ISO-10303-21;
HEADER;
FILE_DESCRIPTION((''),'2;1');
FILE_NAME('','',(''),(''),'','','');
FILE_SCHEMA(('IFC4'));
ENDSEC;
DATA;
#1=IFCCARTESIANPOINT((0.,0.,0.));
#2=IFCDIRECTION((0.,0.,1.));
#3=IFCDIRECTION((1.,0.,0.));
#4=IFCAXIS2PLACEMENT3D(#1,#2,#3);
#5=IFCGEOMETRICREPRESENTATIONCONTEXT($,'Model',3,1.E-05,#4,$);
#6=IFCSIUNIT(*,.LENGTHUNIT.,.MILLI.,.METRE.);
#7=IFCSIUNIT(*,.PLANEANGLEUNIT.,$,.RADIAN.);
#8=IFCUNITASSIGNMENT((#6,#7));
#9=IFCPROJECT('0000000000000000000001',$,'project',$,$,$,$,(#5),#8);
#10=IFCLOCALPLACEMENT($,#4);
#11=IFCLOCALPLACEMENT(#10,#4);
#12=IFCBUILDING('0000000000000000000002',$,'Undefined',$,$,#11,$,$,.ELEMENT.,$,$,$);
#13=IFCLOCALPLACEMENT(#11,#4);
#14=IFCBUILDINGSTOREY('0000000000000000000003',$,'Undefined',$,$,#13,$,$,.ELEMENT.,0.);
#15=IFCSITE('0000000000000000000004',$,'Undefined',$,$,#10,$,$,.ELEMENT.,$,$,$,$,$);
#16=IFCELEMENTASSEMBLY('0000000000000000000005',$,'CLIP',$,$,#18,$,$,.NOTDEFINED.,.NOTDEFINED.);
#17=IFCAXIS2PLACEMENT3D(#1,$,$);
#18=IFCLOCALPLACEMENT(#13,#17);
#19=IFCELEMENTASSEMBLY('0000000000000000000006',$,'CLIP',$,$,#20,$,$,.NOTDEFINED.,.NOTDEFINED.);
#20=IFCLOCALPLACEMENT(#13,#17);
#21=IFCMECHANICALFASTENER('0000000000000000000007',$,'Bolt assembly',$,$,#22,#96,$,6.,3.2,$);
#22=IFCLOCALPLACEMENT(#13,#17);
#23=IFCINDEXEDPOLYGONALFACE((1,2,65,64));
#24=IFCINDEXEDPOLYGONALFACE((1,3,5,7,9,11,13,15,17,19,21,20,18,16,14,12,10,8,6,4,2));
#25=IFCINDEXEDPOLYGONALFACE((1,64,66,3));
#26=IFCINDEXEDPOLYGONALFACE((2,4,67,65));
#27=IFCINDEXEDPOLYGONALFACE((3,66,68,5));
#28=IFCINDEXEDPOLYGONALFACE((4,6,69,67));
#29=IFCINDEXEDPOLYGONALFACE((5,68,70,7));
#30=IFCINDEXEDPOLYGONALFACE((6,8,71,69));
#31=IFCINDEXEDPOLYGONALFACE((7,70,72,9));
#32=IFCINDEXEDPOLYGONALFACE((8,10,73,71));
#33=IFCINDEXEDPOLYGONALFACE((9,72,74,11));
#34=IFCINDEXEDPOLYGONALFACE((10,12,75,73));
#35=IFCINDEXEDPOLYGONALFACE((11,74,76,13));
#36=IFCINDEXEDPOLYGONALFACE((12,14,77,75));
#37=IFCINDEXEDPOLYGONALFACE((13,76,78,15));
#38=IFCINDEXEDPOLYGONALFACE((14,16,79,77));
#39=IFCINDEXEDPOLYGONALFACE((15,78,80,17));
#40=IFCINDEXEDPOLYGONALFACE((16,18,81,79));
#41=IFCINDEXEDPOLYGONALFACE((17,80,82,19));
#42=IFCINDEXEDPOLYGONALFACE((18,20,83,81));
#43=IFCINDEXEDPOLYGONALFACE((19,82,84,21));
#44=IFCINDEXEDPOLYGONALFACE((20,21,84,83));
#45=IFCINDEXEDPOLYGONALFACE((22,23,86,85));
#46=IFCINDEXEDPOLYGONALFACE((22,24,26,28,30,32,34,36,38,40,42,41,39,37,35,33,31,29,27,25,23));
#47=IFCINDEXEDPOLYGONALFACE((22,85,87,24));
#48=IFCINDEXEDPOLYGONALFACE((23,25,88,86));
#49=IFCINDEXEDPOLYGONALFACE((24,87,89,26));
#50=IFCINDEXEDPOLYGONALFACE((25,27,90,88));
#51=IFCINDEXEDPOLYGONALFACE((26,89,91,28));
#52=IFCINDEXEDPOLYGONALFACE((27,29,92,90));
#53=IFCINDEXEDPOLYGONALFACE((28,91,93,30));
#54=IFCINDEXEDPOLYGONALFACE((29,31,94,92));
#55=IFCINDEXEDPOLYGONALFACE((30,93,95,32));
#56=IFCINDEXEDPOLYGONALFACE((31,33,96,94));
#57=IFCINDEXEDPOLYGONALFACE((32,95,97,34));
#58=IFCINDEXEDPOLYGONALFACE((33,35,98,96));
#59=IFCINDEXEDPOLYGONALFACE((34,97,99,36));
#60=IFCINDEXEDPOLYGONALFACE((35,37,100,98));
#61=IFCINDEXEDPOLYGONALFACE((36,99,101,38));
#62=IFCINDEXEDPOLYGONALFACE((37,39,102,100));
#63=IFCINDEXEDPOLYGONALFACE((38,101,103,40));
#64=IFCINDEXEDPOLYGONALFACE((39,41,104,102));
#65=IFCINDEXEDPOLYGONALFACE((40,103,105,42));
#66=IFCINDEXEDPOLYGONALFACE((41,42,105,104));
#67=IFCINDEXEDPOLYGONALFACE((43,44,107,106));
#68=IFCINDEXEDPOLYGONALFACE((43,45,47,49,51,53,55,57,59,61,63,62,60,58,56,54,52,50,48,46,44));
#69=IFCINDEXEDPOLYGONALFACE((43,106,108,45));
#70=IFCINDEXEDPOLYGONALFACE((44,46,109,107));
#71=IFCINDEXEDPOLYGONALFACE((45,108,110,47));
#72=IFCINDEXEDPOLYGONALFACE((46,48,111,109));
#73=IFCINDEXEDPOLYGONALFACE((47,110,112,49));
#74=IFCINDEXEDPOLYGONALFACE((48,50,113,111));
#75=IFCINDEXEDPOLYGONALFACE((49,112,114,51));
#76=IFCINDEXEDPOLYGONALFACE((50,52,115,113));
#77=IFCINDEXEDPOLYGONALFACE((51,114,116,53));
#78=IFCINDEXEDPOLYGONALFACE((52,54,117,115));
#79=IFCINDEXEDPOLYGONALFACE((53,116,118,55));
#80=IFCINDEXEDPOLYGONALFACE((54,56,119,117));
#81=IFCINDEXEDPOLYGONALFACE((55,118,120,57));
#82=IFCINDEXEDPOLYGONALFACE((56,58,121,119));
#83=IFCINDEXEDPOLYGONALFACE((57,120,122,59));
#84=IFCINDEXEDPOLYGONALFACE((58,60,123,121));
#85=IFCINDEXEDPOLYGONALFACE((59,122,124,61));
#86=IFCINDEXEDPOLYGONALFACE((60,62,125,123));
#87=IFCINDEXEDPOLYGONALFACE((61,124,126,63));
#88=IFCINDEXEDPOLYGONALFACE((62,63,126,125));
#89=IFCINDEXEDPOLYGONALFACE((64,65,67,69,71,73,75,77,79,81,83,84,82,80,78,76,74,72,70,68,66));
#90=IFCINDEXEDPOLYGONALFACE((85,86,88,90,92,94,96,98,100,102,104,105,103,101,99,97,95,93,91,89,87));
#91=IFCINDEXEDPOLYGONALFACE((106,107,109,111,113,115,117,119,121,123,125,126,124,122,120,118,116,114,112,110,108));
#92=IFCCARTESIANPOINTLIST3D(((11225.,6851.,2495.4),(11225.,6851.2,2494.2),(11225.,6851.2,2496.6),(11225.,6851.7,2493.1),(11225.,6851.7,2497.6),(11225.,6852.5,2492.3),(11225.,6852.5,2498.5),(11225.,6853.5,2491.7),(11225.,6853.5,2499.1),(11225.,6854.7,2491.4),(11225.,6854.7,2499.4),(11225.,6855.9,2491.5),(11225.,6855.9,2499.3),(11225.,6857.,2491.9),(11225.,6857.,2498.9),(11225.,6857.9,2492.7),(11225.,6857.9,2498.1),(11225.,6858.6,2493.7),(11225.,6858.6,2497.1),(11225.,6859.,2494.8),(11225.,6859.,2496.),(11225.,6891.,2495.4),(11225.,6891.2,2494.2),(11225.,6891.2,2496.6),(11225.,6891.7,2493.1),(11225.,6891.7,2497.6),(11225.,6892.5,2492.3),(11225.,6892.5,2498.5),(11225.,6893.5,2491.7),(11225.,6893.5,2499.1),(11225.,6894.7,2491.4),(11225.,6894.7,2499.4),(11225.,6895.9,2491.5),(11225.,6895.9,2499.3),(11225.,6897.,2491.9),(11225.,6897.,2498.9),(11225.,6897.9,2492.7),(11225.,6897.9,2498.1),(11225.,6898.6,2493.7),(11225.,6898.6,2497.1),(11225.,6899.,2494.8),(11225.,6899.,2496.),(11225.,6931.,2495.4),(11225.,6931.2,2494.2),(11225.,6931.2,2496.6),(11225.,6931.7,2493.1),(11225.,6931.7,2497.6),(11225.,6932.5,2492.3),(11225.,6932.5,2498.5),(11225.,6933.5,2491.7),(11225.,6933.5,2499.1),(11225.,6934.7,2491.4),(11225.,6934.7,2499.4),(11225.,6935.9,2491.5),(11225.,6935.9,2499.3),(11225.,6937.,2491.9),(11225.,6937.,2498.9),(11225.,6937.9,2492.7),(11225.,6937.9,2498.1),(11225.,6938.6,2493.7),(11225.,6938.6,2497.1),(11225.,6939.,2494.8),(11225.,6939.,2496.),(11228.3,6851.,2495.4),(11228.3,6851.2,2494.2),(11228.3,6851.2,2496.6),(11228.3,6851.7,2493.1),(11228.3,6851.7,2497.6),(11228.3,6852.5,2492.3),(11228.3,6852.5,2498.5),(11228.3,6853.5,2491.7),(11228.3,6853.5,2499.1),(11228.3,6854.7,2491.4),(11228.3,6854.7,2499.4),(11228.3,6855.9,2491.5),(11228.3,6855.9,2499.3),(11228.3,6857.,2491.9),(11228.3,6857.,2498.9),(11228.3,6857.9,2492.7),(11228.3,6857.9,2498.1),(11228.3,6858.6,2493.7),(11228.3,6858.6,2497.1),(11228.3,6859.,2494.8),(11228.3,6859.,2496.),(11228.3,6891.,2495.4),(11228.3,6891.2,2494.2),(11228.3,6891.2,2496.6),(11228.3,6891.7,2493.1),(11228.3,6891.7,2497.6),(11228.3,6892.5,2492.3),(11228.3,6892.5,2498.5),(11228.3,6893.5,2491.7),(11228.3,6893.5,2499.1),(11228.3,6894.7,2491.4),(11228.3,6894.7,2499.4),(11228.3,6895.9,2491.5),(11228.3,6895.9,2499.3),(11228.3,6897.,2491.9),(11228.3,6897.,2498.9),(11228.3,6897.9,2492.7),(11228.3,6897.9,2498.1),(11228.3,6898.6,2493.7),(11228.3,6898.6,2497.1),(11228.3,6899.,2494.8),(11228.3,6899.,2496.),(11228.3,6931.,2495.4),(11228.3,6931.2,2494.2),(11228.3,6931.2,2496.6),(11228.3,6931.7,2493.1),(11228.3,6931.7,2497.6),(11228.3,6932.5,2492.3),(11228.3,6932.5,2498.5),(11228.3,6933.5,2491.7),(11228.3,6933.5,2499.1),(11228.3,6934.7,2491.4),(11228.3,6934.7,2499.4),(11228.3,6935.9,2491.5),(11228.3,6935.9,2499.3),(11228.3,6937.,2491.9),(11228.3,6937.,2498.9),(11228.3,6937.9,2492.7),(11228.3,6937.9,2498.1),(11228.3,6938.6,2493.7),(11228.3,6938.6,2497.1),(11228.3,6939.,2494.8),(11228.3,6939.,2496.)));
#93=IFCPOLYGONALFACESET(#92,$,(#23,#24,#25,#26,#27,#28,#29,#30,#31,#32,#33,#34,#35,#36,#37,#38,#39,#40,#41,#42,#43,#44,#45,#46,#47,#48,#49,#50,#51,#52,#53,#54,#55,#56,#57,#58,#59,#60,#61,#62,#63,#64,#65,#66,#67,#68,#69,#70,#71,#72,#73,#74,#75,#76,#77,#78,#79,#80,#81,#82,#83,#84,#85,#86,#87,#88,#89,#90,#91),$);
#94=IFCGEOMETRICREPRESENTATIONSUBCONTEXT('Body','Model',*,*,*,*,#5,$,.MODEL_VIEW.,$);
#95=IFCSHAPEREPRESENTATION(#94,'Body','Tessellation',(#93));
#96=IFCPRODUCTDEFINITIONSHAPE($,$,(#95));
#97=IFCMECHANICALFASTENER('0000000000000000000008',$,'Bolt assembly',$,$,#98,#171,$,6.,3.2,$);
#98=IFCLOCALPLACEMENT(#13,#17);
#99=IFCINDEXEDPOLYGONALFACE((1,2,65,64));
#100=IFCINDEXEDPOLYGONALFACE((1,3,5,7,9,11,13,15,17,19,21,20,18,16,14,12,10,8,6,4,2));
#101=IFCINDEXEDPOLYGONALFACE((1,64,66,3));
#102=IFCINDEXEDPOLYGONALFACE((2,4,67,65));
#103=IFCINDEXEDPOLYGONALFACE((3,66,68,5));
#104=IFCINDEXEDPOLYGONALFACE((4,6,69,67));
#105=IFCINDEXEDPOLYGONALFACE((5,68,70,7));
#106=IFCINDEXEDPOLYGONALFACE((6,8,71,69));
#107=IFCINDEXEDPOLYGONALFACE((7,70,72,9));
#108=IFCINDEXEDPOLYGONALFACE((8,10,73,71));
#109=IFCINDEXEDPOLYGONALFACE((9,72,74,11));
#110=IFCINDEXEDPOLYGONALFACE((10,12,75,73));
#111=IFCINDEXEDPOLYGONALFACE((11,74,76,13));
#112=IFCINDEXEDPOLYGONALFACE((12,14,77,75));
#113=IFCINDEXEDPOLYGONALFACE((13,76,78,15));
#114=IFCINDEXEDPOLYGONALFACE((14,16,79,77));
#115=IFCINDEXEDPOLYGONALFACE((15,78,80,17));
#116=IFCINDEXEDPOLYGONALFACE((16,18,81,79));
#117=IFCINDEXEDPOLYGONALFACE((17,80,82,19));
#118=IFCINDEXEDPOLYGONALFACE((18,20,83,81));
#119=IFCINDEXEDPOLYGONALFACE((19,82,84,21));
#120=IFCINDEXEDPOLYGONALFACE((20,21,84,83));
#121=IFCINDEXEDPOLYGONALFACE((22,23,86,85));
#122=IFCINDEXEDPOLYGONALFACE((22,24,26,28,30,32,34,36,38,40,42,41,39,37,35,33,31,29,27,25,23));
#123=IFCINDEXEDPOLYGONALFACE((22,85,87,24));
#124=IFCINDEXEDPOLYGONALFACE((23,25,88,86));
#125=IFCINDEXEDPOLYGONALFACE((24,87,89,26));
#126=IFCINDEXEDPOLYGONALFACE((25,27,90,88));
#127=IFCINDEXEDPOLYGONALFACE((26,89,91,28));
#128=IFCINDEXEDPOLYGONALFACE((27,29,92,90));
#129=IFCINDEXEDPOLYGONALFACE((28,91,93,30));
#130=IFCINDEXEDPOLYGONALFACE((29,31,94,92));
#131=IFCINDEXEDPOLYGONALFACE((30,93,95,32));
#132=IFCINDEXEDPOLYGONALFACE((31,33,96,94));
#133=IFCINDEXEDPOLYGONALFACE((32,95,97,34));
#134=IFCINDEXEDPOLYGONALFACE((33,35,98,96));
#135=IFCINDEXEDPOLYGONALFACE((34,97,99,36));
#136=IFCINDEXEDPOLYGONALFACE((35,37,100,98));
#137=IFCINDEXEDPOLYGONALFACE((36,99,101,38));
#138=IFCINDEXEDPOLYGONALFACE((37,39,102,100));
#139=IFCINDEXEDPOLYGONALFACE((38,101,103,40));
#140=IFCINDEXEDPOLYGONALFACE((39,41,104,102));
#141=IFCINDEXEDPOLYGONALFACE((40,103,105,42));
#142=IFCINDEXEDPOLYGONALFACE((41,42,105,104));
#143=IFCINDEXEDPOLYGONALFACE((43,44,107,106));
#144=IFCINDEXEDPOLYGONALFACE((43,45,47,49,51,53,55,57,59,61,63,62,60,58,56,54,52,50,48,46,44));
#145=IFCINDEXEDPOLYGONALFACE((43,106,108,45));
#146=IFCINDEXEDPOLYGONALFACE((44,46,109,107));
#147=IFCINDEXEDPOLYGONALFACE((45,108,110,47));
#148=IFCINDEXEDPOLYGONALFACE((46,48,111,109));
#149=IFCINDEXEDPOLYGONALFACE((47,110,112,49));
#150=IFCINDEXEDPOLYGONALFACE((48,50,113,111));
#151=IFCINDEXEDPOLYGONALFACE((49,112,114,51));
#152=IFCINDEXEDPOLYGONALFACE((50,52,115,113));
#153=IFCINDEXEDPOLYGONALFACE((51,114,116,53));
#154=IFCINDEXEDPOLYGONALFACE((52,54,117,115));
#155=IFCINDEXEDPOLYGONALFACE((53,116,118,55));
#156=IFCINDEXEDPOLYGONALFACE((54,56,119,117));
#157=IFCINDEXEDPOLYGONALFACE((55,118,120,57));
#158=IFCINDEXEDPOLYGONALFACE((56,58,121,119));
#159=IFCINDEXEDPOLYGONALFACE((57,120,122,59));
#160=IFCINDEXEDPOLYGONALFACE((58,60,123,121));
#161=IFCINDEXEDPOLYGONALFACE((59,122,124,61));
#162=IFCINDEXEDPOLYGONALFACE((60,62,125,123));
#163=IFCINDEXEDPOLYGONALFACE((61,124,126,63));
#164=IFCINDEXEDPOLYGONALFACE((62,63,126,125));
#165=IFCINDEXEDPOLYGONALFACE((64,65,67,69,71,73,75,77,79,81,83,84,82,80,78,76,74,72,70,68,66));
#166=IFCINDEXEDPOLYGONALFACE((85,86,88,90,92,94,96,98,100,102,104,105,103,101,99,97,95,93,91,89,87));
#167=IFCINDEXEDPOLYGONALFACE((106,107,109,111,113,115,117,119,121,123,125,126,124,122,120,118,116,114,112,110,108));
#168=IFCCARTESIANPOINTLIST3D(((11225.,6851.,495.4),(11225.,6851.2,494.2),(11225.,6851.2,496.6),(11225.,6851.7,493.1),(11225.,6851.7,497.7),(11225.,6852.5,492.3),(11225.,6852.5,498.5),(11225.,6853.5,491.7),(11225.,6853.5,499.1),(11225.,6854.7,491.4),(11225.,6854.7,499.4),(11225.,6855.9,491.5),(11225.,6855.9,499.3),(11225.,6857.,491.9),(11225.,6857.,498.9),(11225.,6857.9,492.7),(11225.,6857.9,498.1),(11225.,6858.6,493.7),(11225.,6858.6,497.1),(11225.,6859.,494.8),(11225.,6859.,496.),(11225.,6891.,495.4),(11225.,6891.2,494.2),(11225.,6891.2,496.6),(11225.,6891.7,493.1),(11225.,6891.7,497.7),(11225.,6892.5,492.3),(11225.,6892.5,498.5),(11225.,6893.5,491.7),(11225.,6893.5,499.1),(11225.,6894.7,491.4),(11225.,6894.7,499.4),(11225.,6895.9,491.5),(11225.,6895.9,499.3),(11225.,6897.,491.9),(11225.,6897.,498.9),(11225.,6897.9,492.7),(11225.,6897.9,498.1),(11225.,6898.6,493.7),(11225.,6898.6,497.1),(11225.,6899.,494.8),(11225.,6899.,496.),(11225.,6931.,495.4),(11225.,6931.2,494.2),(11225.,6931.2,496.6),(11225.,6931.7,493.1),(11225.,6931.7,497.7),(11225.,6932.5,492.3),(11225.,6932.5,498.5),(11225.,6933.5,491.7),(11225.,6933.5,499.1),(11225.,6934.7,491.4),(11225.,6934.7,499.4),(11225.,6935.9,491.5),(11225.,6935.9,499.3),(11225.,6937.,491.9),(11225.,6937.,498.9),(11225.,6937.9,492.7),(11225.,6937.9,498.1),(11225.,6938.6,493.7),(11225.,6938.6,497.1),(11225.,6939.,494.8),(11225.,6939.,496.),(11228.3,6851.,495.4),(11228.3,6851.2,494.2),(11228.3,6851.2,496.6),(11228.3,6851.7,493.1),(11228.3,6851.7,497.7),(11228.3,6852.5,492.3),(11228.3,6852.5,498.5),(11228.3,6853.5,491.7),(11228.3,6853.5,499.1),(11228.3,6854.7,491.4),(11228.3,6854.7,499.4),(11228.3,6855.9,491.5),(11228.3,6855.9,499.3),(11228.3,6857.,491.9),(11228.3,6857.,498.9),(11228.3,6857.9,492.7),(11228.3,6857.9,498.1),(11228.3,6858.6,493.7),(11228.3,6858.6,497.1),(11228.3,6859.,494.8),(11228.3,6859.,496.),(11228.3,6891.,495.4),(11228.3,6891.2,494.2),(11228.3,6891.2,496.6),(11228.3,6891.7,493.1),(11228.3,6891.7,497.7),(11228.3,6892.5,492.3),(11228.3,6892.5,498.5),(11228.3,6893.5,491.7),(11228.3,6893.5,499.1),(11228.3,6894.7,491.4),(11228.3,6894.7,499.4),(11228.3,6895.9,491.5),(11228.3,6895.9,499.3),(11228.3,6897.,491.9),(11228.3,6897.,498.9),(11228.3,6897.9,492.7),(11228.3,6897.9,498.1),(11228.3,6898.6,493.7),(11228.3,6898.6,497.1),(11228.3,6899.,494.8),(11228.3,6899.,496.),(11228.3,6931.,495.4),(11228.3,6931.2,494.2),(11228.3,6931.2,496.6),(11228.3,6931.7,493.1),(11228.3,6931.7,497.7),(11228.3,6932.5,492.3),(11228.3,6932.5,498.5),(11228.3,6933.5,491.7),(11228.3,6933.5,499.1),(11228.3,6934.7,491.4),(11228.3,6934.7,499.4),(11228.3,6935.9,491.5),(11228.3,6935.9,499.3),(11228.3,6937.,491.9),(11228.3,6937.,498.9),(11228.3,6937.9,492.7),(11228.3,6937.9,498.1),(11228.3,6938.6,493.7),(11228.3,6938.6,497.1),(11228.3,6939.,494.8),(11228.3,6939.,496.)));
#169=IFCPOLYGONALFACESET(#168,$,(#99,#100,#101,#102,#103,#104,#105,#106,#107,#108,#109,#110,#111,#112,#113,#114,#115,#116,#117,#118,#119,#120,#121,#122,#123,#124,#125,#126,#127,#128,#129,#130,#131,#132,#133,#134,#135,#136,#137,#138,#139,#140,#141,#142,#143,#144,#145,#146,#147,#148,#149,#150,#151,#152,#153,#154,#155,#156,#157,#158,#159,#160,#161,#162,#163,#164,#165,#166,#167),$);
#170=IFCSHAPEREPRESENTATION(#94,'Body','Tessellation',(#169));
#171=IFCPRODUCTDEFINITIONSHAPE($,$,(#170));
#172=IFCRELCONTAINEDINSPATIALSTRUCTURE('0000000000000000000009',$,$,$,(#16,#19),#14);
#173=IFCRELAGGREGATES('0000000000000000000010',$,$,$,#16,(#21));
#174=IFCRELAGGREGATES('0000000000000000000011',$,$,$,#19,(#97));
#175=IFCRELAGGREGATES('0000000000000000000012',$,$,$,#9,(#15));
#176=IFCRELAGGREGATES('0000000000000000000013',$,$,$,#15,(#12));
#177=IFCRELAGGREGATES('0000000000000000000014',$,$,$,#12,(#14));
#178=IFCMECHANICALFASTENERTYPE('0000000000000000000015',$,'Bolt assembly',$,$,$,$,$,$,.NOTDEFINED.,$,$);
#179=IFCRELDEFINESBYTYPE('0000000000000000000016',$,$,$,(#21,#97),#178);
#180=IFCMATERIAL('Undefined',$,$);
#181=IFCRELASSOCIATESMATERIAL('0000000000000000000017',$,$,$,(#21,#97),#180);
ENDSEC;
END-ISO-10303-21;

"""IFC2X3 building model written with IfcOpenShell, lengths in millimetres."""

from ifc_helpers import new_model, si_unit, frame, origin_with_axes, origin_2d_with_axis, place, context, subcontext, project, spatial, circle, extrude, source, transform, mapped, material, type_object, element, aggregate, save


model = new_model("IFC2X3")

# Units and contexts
model_context = context("Model", 3, precision=1e-05, world=origin_with_axes())
body_context = subcontext(model_context, "Body", "Model", "MODEL_VIEW")
ifc_project = project(units=[si_unit("LENGTHUNIT", "METRE", prefix="MILLI"), si_unit("PLANEANGLEUNIT", "RADIAN")], contexts=[model_context])

# Site, building, storey
site_placement = place(None, origin_with_axes())
site = spatial("IfcSite", under=ifc_project, at=site_placement, Name="Undefined", CompositionType="ELEMENT")
building_placement = place(site_placement, origin_with_axes())
building = spatial("IfcBuilding", under=site, at=building_placement, Name="Undefined", CompositionType="ELEMENT")
storey_placement = place(building_placement, origin_with_axes())
storey = spatial("IfcBuildingStorey", under=building, at=storey_placement, Name="Undefined", CompositionType="ELEMENT", Elevation=0.0)

# Element assemblies
assembly_1_placement = place(storey_placement, origin_with_axes())
assembly_1 = element("IfcElementAssembly", 1, at=assembly_1_placement, inside=storey, Name="CLIP", AssemblyPlace="NOTDEFINED", PredefinedType="NOTDEFINED")
assembly_2_placement = place(storey_placement, origin_with_axes())
assembly_2 = element("IfcElementAssembly", 2, at=assembly_2_placement, inside=storey, Name="CLIP", AssemblyPlace="NOTDEFINED", PredefinedType="NOTDEFINED")

# Mechanical fasteners
ifc_material_1 = material(Name="Undefined")
mechanical_fastener_type = type_object("IfcMechanicalFastenerType", Name="Bolt assembly")
shared_shape_1 = source(origin_with_axes(), body_context, "Body", "SweptSolid", [
    extrude(circle(Radius=4.0, at=origin_2d_with_axis()), frame((0.0, 0.0, 0.0), z_axis=(0.0, 1.0, 0.0), x_axis=(1.0, 0.0, 0.0)), (0.0, 0.0, 1.0), 3.3),
])
mechanical_fastener_1_placement = place(assembly_1_placement, frame((11225.0, 6935.0, 2495.4), z_axis=(0.0, 0.0, 1.0), x_axis=(0.0, -1.0, 0.0)))
mechanical_fastener_1 = element("IfcMechanicalFastener", 3, at=mechanical_fastener_1_placement, type_object=mechanical_fastener_type, material=ifc_material_1, Name="Bolt assembly", NominalDiameter=6.0, NominalLength=3.2, context=body_context, shape_type="MappedRepresentation", body=[
    mapped(shared_shape_1, transform((0.0, 0.0, 0.0))),
    mapped(shared_shape_1, transform((40.0, 0.0, 0.0))),
    mapped(shared_shape_1, transform((80.0, 0.0, 0.0))),
])
aggregate(assembly_1, [mechanical_fastener_1])
mechanical_fastener_2_placement = place(assembly_2_placement, frame((11225.0, 6935.0, 495.4), z_axis=(0.0, 0.0, 1.0), x_axis=(0.0, -1.0, 0.0)))
mechanical_fastener_2 = element("IfcMechanicalFastener", 4, at=mechanical_fastener_2_placement, type_object=mechanical_fastener_type, material=ifc_material_1, Name="Bolt assembly", NominalDiameter=6.0, NominalLength=3.2, context=body_context, shape_type="MappedRepresentation", body=[
    mapped(shared_shape_1, transform((0.0, 0.0, 0.0))),
    mapped(shared_shape_1, transform((40.0, 0.0, 0.0))),
    mapped(shared_shape_1, transform((80.0, 0.0, 0.0))),
])
aggregate(assembly_2, [mechanical_fastener_2])

save(model, "model.ifc")
